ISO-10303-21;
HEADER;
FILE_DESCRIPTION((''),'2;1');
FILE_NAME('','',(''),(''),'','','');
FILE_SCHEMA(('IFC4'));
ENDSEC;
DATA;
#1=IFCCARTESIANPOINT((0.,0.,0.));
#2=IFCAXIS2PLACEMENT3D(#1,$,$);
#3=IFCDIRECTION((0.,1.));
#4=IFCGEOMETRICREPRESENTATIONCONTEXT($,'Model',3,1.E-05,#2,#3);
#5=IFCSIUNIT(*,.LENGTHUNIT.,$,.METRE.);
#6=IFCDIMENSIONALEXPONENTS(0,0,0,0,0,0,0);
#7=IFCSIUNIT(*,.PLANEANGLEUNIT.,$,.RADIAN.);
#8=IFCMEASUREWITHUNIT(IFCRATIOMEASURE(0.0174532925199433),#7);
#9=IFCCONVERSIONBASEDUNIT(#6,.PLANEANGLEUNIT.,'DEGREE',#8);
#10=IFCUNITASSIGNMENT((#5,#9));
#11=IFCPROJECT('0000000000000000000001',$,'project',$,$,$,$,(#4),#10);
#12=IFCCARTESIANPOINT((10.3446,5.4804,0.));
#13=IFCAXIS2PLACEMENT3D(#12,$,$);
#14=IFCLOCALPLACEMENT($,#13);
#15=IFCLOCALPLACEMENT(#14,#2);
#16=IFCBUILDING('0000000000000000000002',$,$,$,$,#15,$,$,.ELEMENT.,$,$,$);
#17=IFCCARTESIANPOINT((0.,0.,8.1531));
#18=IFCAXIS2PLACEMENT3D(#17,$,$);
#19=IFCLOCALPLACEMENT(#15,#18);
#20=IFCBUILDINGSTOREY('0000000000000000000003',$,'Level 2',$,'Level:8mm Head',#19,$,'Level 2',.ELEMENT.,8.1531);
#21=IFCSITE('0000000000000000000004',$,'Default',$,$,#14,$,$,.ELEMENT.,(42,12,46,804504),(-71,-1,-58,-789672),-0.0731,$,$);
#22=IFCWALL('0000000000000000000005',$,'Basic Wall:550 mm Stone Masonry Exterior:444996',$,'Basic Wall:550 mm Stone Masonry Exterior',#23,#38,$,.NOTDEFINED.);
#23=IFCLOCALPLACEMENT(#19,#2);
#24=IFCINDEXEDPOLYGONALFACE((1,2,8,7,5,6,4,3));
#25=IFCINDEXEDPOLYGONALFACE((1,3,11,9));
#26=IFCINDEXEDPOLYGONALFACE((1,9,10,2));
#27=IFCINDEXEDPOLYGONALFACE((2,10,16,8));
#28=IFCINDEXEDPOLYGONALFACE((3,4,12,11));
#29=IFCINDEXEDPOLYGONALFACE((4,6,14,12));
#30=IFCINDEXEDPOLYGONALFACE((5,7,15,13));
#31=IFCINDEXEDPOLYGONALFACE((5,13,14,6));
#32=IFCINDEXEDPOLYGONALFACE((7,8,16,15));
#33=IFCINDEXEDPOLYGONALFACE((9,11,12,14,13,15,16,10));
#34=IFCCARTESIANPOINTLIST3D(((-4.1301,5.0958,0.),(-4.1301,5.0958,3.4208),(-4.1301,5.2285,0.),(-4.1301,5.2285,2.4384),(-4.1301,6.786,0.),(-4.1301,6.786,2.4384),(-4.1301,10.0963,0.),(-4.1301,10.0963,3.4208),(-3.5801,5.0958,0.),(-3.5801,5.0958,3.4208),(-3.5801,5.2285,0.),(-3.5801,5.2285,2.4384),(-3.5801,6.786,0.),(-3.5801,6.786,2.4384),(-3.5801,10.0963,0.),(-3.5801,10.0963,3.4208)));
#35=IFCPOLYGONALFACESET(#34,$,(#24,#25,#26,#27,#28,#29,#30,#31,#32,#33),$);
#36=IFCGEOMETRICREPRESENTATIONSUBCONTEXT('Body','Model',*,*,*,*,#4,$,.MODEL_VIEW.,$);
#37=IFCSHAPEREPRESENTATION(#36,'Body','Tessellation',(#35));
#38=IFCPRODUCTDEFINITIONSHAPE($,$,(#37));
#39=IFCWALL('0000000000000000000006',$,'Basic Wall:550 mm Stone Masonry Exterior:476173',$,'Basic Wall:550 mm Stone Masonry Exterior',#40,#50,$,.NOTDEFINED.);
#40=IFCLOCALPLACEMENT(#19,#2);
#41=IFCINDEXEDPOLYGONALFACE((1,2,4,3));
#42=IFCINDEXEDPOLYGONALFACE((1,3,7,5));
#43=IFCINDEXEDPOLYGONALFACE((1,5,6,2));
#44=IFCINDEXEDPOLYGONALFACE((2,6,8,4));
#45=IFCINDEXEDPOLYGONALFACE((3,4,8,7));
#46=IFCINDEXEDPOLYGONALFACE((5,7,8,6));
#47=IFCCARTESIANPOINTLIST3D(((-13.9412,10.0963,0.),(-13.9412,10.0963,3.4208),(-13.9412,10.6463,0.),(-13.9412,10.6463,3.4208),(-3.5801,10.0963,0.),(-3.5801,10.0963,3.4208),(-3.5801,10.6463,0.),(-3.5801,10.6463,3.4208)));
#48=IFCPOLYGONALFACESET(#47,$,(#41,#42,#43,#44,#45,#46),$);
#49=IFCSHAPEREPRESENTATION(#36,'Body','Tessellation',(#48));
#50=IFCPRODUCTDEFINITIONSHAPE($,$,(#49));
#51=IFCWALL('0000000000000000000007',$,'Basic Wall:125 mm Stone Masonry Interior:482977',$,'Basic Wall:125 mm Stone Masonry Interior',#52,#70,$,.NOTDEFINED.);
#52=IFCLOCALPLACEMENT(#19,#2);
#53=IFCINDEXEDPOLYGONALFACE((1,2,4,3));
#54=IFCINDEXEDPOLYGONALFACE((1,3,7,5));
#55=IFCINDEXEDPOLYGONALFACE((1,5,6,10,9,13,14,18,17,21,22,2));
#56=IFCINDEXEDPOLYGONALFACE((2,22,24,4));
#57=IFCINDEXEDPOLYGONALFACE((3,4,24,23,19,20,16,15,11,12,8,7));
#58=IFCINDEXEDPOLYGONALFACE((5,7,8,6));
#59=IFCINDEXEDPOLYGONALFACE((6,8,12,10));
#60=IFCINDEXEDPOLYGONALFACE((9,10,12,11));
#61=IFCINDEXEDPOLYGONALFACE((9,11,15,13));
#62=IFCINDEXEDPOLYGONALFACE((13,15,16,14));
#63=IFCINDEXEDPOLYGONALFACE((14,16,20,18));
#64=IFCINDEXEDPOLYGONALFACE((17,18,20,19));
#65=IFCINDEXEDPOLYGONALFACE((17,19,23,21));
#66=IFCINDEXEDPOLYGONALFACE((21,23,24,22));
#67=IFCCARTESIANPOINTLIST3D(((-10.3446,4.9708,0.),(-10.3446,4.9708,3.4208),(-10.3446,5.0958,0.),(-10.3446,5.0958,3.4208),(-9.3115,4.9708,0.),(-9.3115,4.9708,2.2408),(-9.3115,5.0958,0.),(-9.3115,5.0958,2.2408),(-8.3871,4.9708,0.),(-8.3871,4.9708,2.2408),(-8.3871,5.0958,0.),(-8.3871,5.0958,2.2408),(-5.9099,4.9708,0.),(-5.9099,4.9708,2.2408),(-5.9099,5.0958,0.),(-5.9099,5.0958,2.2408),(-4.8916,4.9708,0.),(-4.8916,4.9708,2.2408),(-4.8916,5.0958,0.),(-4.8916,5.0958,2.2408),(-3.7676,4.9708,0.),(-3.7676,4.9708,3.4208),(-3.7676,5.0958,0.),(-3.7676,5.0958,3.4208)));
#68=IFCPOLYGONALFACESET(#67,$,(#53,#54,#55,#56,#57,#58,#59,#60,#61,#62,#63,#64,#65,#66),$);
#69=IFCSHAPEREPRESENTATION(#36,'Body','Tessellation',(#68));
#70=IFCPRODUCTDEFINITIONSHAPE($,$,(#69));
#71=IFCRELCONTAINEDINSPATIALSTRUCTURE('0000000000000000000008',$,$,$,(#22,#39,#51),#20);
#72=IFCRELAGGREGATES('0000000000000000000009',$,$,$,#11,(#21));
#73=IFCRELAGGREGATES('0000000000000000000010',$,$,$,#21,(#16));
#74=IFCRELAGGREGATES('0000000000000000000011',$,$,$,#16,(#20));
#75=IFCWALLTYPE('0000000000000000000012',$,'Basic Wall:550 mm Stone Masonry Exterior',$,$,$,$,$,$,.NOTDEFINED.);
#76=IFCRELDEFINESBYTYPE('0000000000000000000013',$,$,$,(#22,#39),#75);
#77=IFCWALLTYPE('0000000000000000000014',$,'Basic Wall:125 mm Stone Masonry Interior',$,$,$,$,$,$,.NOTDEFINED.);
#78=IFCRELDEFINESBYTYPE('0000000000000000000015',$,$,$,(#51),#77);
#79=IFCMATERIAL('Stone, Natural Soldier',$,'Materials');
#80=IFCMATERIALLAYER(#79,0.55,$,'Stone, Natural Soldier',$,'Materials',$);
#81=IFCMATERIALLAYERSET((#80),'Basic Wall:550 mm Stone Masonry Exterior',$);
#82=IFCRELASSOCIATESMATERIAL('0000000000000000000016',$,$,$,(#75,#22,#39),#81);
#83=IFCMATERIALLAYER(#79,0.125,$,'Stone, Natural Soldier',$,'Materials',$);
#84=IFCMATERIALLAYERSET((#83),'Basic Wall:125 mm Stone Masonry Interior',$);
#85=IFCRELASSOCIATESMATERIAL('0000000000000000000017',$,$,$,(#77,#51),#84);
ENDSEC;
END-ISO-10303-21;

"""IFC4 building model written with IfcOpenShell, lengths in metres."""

from ifc_helpers import new_model, entity, si_unit, converted_unit, direction, frame, frame_2d, origin, origin_2d_with_axis, place, context, subcontext, project, spatial, rectangle, extrude, material, layer, layer_set, layer_usage, type_object, element, save


model = new_model("IFC4")

# Units and contexts
model_context = context("Model", 3, precision=1e-05, world=origin(), true_north=direction((0.0, 1.0)))
body_context = subcontext(model_context, "Body", "Model", "MODEL_VIEW")
ifc_project = project(units=[si_unit("LENGTHUNIT", "METRE"), converted_unit("PLANEANGLEUNIT", "DEGREE", entity("IfcRatioMeasure", 0.0174532925199433), si_unit("PLANEANGLEUNIT", "RADIAN"), dimensions=[0, 0, 0, 0, 0, 0, 0])], contexts=[model_context])

# Site, building, storey
site_placement = place(None, frame((10.3446, 5.4804, 0.0)))
site = spatial("IfcSite", under=ifc_project, at=site_placement, Name="Default", CompositionType="ELEMENT", RefLatitude=(42, 12, 46, 804504), RefLongitude=(-71, -1, -58, -789672), RefElevation=-0.0731)
building_placement = place(site_placement, origin())
building = spatial("IfcBuilding", under=site, at=building_placement, CompositionType="ELEMENT")
storey_placement = place(building_placement, frame((0.0, 0.0, 8.1531)))
storey = spatial("IfcBuildingStorey", under=building, at=storey_placement, Name="Level 2", ObjectType="Level:8mm Head", LongName="Level 2", CompositionType="ELEMENT", Elevation=8.1531)

# Wall, opening
ifc_material_1 = material(Name="Stone, Natural Soldier", Category="Materials")
ifc_layer_1 = layer(ifc_material_1, 0.55, Name="Stone, Natural Soldier", Category="Materials")
ifc_layer_set_1 = layer_set([ifc_layer_1], Name="Basic Wall:550 mm Stone Masonry Exterior")
ifc_layer_usage_1 = layer_usage(ifc_layer_set_1, "AXIS2", "NEGATIVE", 0.275)
wall_type_1 = type_object("IfcWallType", Name="Basic Wall:550 mm Stone Masonry Exterior", PredefinedType="NOTDEFINED", material=ifc_layer_set_1)
wall_1_placement = place(storey_placement, frame((-3.8551, 10.0963, 0.0), z_axis=(0.0, 0.0, 1.0), x_axis=(0.0, -1.0, 0.0)))
wall_1 = element("IfcWall", 1, at=wall_1_placement, inside=storey, type_object=wall_type_1, material=ifc_layer_usage_1, Name="Basic Wall:550 mm Stone Masonry Exterior:444996", ObjectType="Basic Wall:550 mm Stone Masonry Exterior", PredefinedType="NOTDEFINED", context=body_context, shape_type="SweptSolid", body=[
    extrude(rectangle(XDim=5.0005, YDim=0.55, at=frame_2d((2.5002, 0.0), x_axis=(-1.0, 0.0))), origin(), (0.0, 0.0, 1.0), 3.4208),
])
opening_1_placement = place(wall_1_placement, frame((4.8678, -0.275, 0.0)))
element("IfcOpeningElement", 2, at=opening_1_placement, cuts=wall_1, ObjectType="Opening", PredefinedType="OPENING", context=body_context, shape_type="SweptSolid", body=[
    extrude(rectangle(XDim=2.4384, YDim=1.5575, at=origin_2d_with_axis()), frame((-0.7787, 0.0, 1.2192), z_axis=(0.0, 1.0, 0.0), x_axis=(0.0, 0.0, -1.0)), (0.0, 0.0, 1.0), 0.55),
])

# Wall
ifc_layer_usage_2 = layer_usage(ifc_layer_set_1, "AXIS2", "NEGATIVE", 0.275)
wall_2_placement = place(storey_placement, frame((-3.5801, 10.3713, 0.0), z_axis=(0.0, 0.0, 1.0), x_axis=(-1.0, 0.0, 0.0)))
element("IfcWall", 3, at=wall_2_placement, inside=storey, type_object=wall_type_1, material=ifc_layer_usage_2, Name="Basic Wall:550 mm Stone Masonry Exterior:476173", ObjectType="Basic Wall:550 mm Stone Masonry Exterior", PredefinedType="NOTDEFINED", context=body_context, shape_type="SweptSolid", body=[
    extrude(rectangle(XDim=10.3611, YDim=0.55, at=frame_2d((5.1805, 0.0), x_axis=(-1.0, 0.0))), origin(), (0.0, 0.0, 1.0), 3.4208),
])

# Wall, openings
ifc_layer_2 = layer(ifc_material_1, 0.125, Name="Stone, Natural Soldier", Category="Materials")
ifc_layer_set_2 = layer_set([ifc_layer_2], Name="Basic Wall:125 mm Stone Masonry Interior")
ifc_layer_usage_3 = layer_usage(ifc_layer_set_2, "AXIS2", "NEGATIVE", 0.0625)
wall_type_2 = type_object("IfcWallType", Name="Basic Wall:125 mm Stone Masonry Interior", PredefinedType="NOTDEFINED", material=ifc_layer_set_2)
wall_3_placement = place(storey_placement, frame((-3.7676, 5.0333, 0.0), z_axis=(0.0, 0.0, 1.0), x_axis=(-1.0, 0.0, 0.0)))
wall_3 = element("IfcWall", 4, at=wall_3_placement, inside=storey, type_object=wall_type_2, material=ifc_layer_usage_3, Name="Basic Wall:125 mm Stone Masonry Interior:482977", ObjectType="Basic Wall:125 mm Stone Masonry Interior", PredefinedType="NOTDEFINED", context=body_context, shape_type="SweptSolid", body=[
    extrude(rectangle(XDim=6.577, YDim=0.125, at=frame_2d((3.2885, 0.0), x_axis=(-1.0, 0.0))), origin(), (0.0, 0.0, 1.0), 3.4208),
])
opening_2_placement = place(wall_3_placement, frame((2.1423, 0.0625, 0.0)))
element("IfcOpeningElement", 5, at=opening_2_placement, cuts=wall_3, ObjectType="Opening", PredefinedType="OPENING", context=body_context, shape_type="SweptSolid", body=[
    extrude(rectangle(XDim=2.2408, YDim=1.0182, at=origin_2d_with_axis()), frame((-0.5091, -0.125, 1.1204), z_axis=(0.0, 1.0, 0.0), x_axis=(0.0, 0.0, -1.0)), (0.0, 0.0, 1.0), 0.125),
])
opening_3_placement = place(wall_3_placement, frame((5.5439, 0.0625, 0.0)))
element("IfcOpeningElement", 6, at=opening_3_placement, cuts=wall_3, ObjectType="Opening", PredefinedType="OPENING", context=body_context, shape_type="SweptSolid", body=[
    extrude(rectangle(XDim=2.2408, YDim=0.9245, at=frame_2d((0.0, 0.0), x_axis=(1.0, 0.0))), frame((-0.4622, -0.125, 1.1204), z_axis=(0.0, 1.0, 0.0), x_axis=(0.0, 0.0, -1.0)), (0.0, 0.0, 1.0), 0.125),
])

save(model, "model.ifc")
